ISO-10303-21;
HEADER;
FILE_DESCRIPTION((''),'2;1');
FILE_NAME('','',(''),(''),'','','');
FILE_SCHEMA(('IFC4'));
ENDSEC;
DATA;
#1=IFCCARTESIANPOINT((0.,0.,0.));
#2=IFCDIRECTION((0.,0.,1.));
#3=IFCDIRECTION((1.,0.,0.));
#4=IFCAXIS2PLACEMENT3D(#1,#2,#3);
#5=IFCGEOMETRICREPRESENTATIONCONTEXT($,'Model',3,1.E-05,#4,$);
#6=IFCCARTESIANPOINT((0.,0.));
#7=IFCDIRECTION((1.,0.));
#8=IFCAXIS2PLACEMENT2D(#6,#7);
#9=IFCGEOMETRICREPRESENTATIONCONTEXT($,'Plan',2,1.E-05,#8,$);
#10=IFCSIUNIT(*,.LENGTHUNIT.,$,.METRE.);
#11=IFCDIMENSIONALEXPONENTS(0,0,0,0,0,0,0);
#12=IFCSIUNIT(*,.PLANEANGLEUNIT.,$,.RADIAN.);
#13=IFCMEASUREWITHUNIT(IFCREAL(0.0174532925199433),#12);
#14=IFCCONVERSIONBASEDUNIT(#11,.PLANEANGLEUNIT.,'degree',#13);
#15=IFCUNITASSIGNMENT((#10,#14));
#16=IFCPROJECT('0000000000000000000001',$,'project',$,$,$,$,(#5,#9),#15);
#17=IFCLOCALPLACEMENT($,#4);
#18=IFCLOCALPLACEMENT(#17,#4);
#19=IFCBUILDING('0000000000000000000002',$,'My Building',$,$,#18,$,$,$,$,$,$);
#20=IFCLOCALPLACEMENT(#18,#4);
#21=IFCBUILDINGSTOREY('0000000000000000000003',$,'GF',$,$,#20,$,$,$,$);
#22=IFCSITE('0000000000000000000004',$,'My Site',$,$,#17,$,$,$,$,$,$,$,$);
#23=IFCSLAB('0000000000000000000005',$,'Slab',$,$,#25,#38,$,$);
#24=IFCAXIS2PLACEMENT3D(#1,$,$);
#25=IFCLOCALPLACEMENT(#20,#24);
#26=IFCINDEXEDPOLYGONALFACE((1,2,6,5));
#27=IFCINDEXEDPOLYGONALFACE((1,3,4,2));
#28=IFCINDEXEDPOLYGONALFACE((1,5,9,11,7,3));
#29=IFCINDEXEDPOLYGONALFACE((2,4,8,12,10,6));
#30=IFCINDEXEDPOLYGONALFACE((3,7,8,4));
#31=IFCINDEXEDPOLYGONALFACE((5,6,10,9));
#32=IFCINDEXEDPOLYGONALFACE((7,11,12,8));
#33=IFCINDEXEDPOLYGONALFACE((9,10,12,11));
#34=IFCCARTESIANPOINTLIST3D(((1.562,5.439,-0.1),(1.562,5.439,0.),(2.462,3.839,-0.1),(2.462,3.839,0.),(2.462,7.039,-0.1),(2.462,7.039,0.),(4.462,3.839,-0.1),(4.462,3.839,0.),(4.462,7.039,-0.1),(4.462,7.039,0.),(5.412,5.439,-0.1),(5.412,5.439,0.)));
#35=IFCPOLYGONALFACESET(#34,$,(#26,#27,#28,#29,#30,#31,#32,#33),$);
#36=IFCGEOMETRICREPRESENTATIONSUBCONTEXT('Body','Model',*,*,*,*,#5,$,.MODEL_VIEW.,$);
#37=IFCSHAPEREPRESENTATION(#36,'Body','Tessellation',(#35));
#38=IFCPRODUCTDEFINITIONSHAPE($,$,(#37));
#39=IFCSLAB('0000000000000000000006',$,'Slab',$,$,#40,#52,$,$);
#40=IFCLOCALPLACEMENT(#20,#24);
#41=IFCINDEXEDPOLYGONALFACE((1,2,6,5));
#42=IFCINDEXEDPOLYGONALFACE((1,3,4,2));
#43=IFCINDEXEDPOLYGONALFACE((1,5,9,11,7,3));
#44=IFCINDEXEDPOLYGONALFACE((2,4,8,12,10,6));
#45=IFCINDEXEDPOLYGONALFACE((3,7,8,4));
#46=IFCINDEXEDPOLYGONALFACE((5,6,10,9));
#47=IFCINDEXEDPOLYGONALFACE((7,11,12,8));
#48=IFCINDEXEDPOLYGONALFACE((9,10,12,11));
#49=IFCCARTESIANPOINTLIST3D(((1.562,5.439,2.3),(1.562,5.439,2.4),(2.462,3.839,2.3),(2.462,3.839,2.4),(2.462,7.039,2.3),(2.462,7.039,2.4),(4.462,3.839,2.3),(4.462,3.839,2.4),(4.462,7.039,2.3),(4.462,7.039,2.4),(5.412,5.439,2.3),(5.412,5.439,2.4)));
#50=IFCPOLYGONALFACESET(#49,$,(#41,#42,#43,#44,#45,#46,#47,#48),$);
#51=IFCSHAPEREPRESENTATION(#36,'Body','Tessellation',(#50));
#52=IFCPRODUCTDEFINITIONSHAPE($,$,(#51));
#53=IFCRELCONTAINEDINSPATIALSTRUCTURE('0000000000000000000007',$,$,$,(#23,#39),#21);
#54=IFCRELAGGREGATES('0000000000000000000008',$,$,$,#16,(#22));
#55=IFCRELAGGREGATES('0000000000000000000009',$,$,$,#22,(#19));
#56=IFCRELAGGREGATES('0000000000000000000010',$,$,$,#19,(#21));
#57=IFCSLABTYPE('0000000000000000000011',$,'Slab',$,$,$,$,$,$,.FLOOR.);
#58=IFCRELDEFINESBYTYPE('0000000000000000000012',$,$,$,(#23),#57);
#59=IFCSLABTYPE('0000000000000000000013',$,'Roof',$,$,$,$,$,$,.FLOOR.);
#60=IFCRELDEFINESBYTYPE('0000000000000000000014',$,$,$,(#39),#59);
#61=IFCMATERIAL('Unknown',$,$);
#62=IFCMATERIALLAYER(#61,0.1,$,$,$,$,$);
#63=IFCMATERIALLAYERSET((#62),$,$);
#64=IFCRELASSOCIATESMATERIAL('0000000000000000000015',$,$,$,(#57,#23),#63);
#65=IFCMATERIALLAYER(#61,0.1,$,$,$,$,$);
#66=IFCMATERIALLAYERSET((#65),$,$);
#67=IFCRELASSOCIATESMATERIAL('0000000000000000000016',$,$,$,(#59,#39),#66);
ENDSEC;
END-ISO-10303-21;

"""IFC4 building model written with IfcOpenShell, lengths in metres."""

from ifc_helpers import new_model, entity, si_unit, converted_unit, frame, origin_with_axes, origin_2d_with_axis, place, context, subcontext, project, spatial, indexed_curve, outline, extrude, material, layer, layer_set, layer_usage, type_object, element, save


model = new_model("IFC4")

# Units and contexts
model_context = context("Model", 3, precision=1e-05, world=origin_with_axes())
plan_context = context("Plan", 2, precision=1e-05, world=origin_2d_with_axis())
body_context = subcontext(model_context, "Body", "Model", "MODEL_VIEW")
ifc_project = project(units=[si_unit("LENGTHUNIT", "METRE"), converted_unit("PLANEANGLEUNIT", "degree", entity("IfcReal", 0.0174532925199433), si_unit("PLANEANGLEUNIT", "RADIAN"), dimensions=[0, 0, 0, 0, 0, 0, 0])], contexts=[model_context, plan_context])

# Site, building, storey
site_placement = place(None, origin_with_axes())
site = spatial("IfcSite", under=ifc_project, at=site_placement, Name="My Site")
building_placement = place(site_placement, origin_with_axes())
building = spatial("IfcBuilding", under=site, at=building_placement, Name="My Building")
storey_placement = place(building_placement, origin_with_axes())
storey = spatial("IfcBuildingStorey", under=building, at=storey_placement, Name="GF")

# Slabs
ifc_material = material(Name="Unknown")
ifc_layer_1 = layer(ifc_material, 0.1)
ifc_layer_set_1 = layer_set([ifc_layer_1])
ifc_layer_usage_1 = layer_usage(ifc_layer_set_1, "AXIS3", "POSITIVE", -0.1)
slab_type_1 = type_object("IfcSlabType", Name="Slab", PredefinedType="FLOOR", material=ifc_layer_set_1)
slab_1_placement = place(storey_placement, frame((2.462, 7.039, 0.0), z_axis=(0.0, 0.0, 1.0), x_axis=(1.0, 0.0, 0.0)))
element("IfcSlab", 1, at=slab_1_placement, inside=storey, type_object=slab_type_1, material=ifc_layer_usage_1, Name="Slab", context=body_context, shape_type="SweptSolid", body=[
    extrude(outline(indexed_curve([(-0.9, -1.6), (0.0, -3.2), (2.0, -3.2), (2.95, -1.6), (2.0, 0.0), (0.0, 0.0), (-0.9, -1.6)])), frame((0.0, 0.0, -0.1), z_axis=(0.0, 0.0, 1.0), x_axis=(1.0, 0.0, 0.0)), (0.0, 0.0, 1.0), 0.1),
])
ifc_layer_2 = layer(ifc_material, 0.1)
ifc_layer_set_2 = layer_set([ifc_layer_2])
ifc_layer_usage_2 = layer_usage(ifc_layer_set_2, "AXIS3", "POSITIVE", -0.1)
slab_type_2 = type_object("IfcSlabType", Name="Roof", PredefinedType="FLOOR", material=ifc_layer_set_2)
slab_2_placement = place(storey_placement, frame((2.462, 7.039, 2.4), z_axis=(0.0, 0.0, 1.0), x_axis=(1.0, 0.0, 0.0)))
element("IfcSlab", 2, at=slab_2_placement, inside=storey, type_object=slab_type_2, material=ifc_layer_usage_2, Name="Slab", context=body_context, shape_type="SweptSolid", body=[
    extrude(outline(indexed_curve([(0.0, 0.0), (2.0, 0.0), (2.95, -1.6), (2.0, -3.2), (0.0, -3.2), (-0.9, -1.6), (0.0, 0.0)])), frame((0.0, 0.0, -0.1), z_axis=(0.0, 0.0, 1.0), x_axis=(1.0, 0.0, 0.0)), (0.0, 0.0, 1.0), 0.1),
])

save(model, "model.ifc")
